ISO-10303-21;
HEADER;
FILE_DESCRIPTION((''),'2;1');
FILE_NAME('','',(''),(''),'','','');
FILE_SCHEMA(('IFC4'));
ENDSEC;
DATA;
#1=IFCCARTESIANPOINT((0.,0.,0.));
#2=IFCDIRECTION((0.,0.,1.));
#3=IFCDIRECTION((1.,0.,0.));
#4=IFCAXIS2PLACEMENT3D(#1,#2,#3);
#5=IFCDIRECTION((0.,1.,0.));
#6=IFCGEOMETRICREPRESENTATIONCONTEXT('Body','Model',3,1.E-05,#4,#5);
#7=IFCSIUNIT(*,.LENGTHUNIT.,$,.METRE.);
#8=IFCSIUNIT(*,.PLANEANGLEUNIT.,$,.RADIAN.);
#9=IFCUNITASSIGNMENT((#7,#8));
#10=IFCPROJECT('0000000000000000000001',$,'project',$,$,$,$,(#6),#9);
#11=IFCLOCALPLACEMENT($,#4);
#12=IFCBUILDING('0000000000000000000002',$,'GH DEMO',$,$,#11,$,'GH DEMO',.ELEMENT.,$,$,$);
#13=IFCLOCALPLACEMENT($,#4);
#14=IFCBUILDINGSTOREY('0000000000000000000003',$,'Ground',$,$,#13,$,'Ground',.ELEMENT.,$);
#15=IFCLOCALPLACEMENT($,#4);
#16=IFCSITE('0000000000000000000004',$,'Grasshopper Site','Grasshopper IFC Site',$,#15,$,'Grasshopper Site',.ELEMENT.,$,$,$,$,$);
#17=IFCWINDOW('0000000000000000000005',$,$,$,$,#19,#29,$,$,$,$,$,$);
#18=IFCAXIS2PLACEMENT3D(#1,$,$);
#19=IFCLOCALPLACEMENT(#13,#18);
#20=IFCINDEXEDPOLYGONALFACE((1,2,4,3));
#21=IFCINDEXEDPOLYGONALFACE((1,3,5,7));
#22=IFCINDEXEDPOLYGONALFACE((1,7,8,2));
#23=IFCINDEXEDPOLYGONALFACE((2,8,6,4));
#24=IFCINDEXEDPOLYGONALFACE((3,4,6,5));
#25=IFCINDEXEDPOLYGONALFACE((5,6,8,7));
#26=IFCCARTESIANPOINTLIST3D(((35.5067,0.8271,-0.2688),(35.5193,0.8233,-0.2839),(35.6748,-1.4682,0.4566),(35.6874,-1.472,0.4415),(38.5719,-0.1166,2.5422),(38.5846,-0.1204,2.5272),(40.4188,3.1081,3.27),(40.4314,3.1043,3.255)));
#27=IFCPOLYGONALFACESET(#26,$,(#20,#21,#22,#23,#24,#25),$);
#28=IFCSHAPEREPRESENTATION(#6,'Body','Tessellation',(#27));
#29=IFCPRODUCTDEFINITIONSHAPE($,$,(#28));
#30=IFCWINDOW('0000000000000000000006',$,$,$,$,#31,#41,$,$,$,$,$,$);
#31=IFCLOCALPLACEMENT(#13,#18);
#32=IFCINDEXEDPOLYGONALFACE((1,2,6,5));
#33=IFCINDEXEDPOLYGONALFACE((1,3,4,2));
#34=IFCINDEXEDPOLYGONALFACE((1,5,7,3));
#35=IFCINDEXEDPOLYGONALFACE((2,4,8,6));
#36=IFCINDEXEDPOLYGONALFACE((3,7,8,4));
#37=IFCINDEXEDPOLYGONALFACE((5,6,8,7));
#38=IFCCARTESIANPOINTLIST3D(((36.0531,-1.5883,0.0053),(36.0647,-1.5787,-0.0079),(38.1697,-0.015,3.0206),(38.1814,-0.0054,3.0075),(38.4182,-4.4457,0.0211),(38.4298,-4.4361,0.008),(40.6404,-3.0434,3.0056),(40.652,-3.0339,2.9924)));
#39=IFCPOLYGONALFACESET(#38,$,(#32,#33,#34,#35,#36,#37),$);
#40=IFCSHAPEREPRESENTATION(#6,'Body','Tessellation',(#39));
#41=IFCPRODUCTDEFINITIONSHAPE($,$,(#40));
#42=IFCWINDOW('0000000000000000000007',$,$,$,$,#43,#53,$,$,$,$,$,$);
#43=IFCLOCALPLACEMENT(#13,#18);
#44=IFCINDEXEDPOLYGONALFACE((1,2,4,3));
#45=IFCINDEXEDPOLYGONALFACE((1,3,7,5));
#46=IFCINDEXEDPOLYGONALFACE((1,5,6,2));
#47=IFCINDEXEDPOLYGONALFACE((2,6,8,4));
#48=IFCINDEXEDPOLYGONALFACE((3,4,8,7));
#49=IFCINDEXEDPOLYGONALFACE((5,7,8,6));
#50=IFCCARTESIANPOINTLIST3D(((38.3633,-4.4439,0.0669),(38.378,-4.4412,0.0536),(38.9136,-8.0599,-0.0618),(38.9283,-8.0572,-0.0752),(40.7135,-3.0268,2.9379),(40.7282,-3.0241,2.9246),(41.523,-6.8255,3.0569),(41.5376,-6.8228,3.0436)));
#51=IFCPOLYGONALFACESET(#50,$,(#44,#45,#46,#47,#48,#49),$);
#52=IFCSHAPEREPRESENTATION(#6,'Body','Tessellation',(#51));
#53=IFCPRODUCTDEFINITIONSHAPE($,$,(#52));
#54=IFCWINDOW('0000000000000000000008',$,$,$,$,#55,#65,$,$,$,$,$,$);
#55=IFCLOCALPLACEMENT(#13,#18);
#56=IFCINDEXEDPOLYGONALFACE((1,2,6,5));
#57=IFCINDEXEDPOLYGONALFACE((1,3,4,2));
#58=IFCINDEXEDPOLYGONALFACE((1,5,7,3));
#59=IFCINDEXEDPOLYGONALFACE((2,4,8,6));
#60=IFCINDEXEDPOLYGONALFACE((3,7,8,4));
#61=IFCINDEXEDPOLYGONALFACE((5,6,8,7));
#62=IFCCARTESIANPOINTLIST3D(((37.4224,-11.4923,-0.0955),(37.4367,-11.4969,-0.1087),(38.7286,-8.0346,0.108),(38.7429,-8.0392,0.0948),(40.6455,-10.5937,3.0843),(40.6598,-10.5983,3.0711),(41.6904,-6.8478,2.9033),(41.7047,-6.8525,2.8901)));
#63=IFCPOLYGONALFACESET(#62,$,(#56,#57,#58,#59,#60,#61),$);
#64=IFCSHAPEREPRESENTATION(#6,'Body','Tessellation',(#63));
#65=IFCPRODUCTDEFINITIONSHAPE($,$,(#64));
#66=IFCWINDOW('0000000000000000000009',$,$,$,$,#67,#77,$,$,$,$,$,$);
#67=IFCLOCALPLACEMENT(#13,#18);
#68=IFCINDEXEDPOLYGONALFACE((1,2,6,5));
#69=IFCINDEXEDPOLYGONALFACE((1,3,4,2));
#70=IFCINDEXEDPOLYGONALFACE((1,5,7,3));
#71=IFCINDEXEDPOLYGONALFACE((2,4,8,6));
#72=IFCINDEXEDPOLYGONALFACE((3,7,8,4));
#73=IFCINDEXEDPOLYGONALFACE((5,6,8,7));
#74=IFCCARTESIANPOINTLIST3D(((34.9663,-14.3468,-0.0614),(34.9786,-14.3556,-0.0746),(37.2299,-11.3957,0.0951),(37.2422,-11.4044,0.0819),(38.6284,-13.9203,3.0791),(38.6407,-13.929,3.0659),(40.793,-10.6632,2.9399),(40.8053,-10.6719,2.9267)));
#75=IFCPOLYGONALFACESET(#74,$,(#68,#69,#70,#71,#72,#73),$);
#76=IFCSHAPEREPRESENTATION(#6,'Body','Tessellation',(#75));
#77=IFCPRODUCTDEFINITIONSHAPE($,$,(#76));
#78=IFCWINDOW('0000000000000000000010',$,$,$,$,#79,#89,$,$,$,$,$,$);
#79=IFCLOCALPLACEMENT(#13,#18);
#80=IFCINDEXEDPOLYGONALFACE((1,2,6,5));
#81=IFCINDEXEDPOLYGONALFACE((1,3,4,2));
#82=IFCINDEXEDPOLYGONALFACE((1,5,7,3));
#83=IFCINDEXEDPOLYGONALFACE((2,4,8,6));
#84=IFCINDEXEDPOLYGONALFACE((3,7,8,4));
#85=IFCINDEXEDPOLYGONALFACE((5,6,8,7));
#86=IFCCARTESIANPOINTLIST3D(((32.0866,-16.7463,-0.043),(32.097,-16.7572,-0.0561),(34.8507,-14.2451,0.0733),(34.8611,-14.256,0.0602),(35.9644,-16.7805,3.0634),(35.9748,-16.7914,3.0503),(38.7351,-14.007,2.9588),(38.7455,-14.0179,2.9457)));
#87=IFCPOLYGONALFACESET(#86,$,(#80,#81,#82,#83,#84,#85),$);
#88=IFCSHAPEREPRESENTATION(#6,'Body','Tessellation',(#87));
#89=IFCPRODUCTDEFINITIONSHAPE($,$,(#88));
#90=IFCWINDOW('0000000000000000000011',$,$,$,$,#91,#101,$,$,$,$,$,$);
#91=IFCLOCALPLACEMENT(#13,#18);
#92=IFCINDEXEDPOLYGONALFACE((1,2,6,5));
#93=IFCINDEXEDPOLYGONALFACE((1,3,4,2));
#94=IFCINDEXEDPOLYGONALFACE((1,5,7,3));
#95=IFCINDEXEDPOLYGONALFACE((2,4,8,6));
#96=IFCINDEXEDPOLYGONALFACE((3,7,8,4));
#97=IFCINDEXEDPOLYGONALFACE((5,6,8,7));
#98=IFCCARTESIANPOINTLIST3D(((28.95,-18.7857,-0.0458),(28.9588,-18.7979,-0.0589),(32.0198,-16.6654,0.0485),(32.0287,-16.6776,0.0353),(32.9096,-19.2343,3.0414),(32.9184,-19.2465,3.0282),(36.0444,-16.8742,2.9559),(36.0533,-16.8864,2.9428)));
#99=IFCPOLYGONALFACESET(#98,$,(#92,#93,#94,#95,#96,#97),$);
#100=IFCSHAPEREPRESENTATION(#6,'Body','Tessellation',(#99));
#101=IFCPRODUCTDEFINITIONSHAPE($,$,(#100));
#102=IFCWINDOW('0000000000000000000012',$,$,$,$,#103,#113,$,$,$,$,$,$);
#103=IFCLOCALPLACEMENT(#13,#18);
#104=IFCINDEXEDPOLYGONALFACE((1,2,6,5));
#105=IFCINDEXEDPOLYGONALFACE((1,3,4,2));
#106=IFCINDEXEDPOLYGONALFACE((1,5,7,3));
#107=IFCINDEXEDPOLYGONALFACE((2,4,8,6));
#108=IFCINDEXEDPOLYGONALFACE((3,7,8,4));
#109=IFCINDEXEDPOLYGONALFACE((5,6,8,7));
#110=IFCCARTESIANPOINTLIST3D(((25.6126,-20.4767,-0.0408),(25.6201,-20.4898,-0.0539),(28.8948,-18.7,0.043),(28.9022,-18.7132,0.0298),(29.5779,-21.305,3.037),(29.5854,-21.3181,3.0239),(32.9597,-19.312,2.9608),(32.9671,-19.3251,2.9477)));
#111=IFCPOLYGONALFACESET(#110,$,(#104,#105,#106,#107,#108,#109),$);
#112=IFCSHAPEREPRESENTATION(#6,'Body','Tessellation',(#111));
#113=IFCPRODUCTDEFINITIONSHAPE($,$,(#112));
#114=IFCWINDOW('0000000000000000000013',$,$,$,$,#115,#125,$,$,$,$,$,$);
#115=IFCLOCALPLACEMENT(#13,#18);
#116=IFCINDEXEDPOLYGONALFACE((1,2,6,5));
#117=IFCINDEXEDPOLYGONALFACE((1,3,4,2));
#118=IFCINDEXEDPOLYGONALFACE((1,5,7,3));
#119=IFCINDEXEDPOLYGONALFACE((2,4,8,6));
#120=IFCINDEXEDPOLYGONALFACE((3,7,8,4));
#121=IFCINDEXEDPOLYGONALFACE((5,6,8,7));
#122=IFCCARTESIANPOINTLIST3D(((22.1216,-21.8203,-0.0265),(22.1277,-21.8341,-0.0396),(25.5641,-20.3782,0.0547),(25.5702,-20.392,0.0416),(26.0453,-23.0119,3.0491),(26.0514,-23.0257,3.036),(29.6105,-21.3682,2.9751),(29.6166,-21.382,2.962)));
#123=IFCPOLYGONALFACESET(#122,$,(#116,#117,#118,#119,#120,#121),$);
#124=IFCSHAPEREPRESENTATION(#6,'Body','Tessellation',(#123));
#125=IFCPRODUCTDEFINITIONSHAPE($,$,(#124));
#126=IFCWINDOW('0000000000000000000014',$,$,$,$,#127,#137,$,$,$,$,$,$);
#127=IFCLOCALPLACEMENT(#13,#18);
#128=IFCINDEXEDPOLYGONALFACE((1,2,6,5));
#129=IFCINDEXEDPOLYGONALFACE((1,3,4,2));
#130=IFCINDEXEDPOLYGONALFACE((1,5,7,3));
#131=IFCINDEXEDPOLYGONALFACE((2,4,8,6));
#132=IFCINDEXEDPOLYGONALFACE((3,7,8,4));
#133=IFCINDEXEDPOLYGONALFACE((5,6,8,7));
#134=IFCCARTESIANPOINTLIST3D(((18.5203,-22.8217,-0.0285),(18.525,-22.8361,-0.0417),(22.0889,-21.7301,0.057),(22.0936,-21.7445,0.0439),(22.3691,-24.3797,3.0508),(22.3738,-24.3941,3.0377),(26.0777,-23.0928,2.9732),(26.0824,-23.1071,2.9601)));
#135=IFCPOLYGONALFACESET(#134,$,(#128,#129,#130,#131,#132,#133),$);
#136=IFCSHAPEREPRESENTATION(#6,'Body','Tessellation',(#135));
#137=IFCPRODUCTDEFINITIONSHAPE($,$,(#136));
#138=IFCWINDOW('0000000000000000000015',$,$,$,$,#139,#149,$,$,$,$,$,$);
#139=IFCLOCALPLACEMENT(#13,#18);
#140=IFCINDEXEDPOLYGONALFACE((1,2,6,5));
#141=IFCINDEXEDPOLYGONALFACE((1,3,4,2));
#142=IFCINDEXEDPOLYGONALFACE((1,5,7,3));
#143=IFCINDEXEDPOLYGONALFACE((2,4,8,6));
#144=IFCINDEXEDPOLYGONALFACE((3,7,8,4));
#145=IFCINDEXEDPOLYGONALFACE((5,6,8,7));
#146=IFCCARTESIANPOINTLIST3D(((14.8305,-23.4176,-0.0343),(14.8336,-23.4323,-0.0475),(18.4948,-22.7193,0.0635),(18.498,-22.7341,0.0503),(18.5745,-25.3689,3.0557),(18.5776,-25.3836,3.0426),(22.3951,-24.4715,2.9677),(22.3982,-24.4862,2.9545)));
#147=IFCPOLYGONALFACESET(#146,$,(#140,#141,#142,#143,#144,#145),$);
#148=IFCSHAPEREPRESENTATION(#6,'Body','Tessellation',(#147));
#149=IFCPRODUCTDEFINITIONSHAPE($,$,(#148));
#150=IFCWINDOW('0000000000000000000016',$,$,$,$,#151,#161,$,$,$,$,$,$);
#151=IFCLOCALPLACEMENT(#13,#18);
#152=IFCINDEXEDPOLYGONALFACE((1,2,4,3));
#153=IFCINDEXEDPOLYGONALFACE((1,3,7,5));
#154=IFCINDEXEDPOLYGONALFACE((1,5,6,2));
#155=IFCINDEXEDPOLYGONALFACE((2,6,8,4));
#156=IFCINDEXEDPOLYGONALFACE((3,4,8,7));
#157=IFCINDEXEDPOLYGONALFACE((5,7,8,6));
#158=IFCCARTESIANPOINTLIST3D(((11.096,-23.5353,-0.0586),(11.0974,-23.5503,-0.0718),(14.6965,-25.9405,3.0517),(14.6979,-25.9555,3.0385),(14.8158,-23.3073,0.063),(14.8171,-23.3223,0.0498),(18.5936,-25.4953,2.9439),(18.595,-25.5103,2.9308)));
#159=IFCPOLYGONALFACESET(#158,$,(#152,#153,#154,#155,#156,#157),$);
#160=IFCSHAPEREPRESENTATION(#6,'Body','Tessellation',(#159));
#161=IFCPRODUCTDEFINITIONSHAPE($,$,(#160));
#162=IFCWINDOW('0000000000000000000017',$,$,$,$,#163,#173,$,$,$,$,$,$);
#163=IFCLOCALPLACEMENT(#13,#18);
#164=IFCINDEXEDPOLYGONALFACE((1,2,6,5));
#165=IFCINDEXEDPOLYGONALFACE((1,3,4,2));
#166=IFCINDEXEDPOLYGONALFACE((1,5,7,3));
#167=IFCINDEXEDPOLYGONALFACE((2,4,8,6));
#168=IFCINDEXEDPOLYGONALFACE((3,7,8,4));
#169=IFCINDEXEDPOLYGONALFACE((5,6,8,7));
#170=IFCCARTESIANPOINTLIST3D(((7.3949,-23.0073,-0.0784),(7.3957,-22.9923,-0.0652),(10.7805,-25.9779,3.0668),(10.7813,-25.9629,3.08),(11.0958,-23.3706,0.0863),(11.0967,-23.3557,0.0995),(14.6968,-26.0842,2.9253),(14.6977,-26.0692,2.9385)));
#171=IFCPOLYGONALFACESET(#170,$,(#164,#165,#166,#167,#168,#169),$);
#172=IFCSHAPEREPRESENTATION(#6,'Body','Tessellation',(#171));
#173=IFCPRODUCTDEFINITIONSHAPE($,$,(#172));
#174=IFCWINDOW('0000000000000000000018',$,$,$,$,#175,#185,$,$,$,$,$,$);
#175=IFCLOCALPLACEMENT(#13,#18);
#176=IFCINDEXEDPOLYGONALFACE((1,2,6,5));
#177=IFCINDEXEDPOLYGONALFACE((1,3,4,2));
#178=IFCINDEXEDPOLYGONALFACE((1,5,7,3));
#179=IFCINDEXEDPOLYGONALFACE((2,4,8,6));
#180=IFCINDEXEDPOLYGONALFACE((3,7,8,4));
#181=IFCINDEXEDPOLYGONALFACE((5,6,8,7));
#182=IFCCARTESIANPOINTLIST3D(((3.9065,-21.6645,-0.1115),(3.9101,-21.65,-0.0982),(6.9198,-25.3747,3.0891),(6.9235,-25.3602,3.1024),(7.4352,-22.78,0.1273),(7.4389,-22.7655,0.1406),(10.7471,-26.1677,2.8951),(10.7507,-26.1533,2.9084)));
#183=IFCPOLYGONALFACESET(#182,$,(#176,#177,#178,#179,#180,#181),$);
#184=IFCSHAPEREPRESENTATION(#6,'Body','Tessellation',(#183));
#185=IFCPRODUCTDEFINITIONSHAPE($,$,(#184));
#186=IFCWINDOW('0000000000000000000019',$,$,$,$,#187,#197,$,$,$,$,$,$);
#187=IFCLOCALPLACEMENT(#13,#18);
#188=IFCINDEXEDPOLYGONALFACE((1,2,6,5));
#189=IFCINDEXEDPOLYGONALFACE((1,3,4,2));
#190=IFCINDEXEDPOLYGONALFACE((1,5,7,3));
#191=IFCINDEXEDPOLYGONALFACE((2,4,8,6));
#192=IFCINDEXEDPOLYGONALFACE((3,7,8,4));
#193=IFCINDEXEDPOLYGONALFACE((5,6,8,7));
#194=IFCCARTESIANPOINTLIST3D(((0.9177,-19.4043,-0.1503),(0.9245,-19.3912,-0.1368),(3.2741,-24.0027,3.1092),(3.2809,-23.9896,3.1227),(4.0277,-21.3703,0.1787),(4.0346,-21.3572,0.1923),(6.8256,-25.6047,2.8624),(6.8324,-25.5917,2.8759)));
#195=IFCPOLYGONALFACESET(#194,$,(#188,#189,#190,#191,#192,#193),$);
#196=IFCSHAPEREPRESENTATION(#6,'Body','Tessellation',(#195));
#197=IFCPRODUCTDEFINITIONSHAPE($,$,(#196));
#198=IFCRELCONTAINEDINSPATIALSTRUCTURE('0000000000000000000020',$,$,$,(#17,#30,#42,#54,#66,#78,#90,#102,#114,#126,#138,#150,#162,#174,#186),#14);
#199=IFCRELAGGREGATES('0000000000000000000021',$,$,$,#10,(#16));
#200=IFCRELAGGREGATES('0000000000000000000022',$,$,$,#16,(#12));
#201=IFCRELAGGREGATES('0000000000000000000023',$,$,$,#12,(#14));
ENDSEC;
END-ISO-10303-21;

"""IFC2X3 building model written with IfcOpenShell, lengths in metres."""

from ifc_helpers import new_model, si_unit, direction, frame, origin_with_axes, place, context, project, spatial, polyline, outline, extrude, element, save


model = new_model("IFC2X3")

# Units and contexts
model_context = context("Model", 3, precision=1e-05, world=origin_with_axes(), true_north=direction((0.0, 1.0, 0.0)), identifier="Body")
ifc_project = project(units=[si_unit("LENGTHUNIT", "METRE"), si_unit("PLANEANGLEUNIT", "RADIAN")], contexts=[model_context])

# Site, building, storey
site_placement = place(None, origin_with_axes())
site = spatial("IfcSite", under=ifc_project, at=site_placement, Name="Grasshopper Site", Description="Grasshopper IFC Site", LongName="Grasshopper Site", CompositionType="ELEMENT")
building_placement = place(None, origin_with_axes())
building = spatial("IfcBuilding", under=site, at=building_placement, Name="GH DEMO", LongName="GH DEMO", CompositionType="ELEMENT")
storey_placement = place(None, origin_with_axes())
storey = spatial("IfcBuildingStorey", under=building, at=storey_placement, Name="Ground", LongName="Ground", CompositionType="ELEMENT")

# Windows
window_1_placement = place(None, origin_with_axes())
element("IfcWindow", 1, at=window_1_placement, inside=storey, context=model_context, shape_type="SweptSolid", body=[
    extrude(outline(polyline([(0.0, 0.0), (6.4696, 0.0), (3.5322, 2.3898), (-0.2849, 2.3961), (0.0, 0.0)])), frame((35.5067, 0.8271, -0.2688), z_axis=(0.630711, -0.191495, -0.75202), x_axis=(0.75926, 0.35258, 0.547002)), (0.0, 0.0, 1.0), 0.02),
])
window_2_placement = place(None, origin_with_axes())
element("IfcWindow", 2, at=window_2_placement, inside=storey, context=model_context, shape_type="SweptSolid", body=[
    extrude(outline(polyline([(0.0, 0.0), (4.006, 0.0), (4.1108, 3.907), (0.1395, 3.7067), (0.0, 0.0)])), frame((36.0647, -1.5787, -0.0079), z_axis=(0.581941, 0.478026, -0.657903), x_axis=(0.528377, 0.392723, 0.752719)), (0.0, 0.0, -1.0), 0.02),
])
window_3_placement = place(None, origin_with_axes())
element("IfcWindow", 3, at=window_3_placement, inside=storey, context=model_context, shape_type="SweptSolid", body=[
    extrude(outline(polyline([(0.0, 0.0), (3.9717, 0.0), (3.1813, 3.8046), (-1.0577, 3.5038), (0.0, 0.0)])), frame((38.3633, -4.4439, 0.0669), z_axis=(0.732908, 0.135283, -0.666742), x_axis=(0.591742, 0.356808, 0.722862)), (0.0, 0.0, 1.0), 0.02),
])
window_4_placement = place(None, origin_with_axes())
element("IfcWindow", 4, at=window_4_placement, inside=storey, context=model_context, shape_type="SweptSolid", body=[
    extrude(outline(polyline([(0.0, 0.0), (4.242, 0.0), (2.5837, 3.5223), (-2.0134, 3.1064), (0.0, 0.0)])), frame((38.7286, -8.0346, 0.108), z_axis=(0.715186, -0.231353, -0.659534), x_axis=(0.698199, 0.279765, 0.658977)), (0.0, 0.0, 1.0), 0.02),
])
window_5_placement = place(None, origin_with_axes())
element("IfcWindow", 5, at=window_5_placement, inside=storey, context=model_context, shape_type="SweptSolid", body=[
    extrude(outline(polyline([(0.0, 0.0), (4.6179, 0.0), (2.5169, 3.3014), (-2.3111, 2.9184), (0.0, 0.0)])), frame((37.2422, -11.4044, 0.0819), z_axis=(0.614461, -0.436451, -0.657228), x_axis=(0.771581, 0.158615, 0.616039)), (0.0, 0.0, -1.0), 0.02),
])
window_6_placement = place(None, origin_with_axes())
element("IfcWindow", 6, at=window_6_placement, inside=storey, context=model_context, shape_type="SweptSolid", body=[
    extrude(outline(polyline([(0.0, 0.0), (4.8447, 0.0), (2.5492, 3.1797), (-2.4084, 2.8476), (0.0, 0.0)])), frame((34.8611, -14.256, 0.0602), z_axis=(0.521115, -0.545356, -0.656526), x_axis=(0.801786, 0.049149, 0.595587)), (0.0, 0.0, -1.0), 0.02),
])
window_7_placement = place(None, origin_with_axes())
element("IfcWindow", 7, at=window_7_placement, inside=storey, context=model_context, shape_type="SweptSolid", body=[
    extrude(outline(polyline([(0.0, 0.0), (4.9693, 0.0), (2.5796, 3.1135), (-2.4523, 2.8133), (0.0, 0.0)])), frame((32.0198, -16.6654, 0.0485), z_axis=(0.442357, -0.611313, -0.656214), x_axis=(0.809884, -0.042013, 0.585084)), (0.0, 0.0, 1.0), 0.02),
])
window_8_placement = place(None, origin_with_axes())
element("IfcWindow", 8, at=window_8_placement, inside=storey, context=model_context, shape_type="SweptSolid", body=[
    extrude(outline(polyline([(0.0, 0.0), (5.041, 0.0), (2.6002, 3.0751), (-2.4794, 2.7907), (0.0, 0.0)])), frame((28.8948, -18.7, 0.043), z_axis=(0.37213, -0.656532, -0.656114), x_axis=(0.806367, -0.121396, 0.578822)), (0.0, 0.0, 1.0), 0.02),
])
window_9_placement = place(None, origin_with_axes())
element("IfcWindow", 9, at=window_9_placement, inside=storey, context=model_context, shape_type="SweptSolid", body=[
    extrude(outline(polyline([(0.0, 0.0), (5.0874, 0.0), (2.6142, 3.0496), (-2.5041, 2.7689), (0.0, 0.0)])), frame((25.5702, -20.392, 0.0416), z_axis=(0.304678, -0.690364, -0.656178), x_axis=(0.795367, -0.194596, 0.574041)), (0.0, 0.0, -1.0), 0.02),
])
window_10_placement = place(None, origin_with_axes())
element("IfcWindow", 10, at=window_10_placement, inside=storey, context=model_context, shape_type="SweptSolid", body=[
    extrude(outline(polyline([(0.0, 0.0), (5.1256, 0.0), (2.6258, 3.0277), (-2.5356, 2.7394), (0.0, 0.0)])), frame((22.0936, -21.7445, 0.0439), z_axis=(0.235014, -0.716849, -0.656427), x_axis=(0.77822, -0.265853, 0.568942)), (0.0, 0.0, -1.0), 0.02),
])
window_11_placement = place(None, origin_with_axes())
element("IfcWindow", 11, at=window_11_placement, inside=storey, context=model_context, shape_type="SweptSolid", body=[
    extrude(outline(polyline([(0.0, 0.0), (5.1688, 0.0), (2.6395, 3.0021), (-2.5833, 2.6928), (0.0, 0.0)])), frame((18.498, -22.7341, 0.0503), z_axis=(0.158012, -0.737178, -0.656963), x_axis=(0.75458, -0.338988, 0.561869)), (0.0, 0.0, -1.0), 0.02),
])
window_12_placement = place(None, origin_with_axes())
element("IfcWindow", 12, at=window_12_placement, inside=storey, context=model_context, shape_type="SweptSolid", body=[
    extrude(outline(polyline([(0.0, 0.0), (5.2306, 0.0), (2.6615, 2.9659), (-2.6582, 2.6148), (0.0, 0.0)])), frame((14.8158, -23.3073, 0.063), z_axis=(0.067491, -0.749936, -0.658059), x_axis=(0.722258, -0.418306, 0.550784)), (0.0, 0.0, 1.0), 0.02),
])
window_13_placement = place(None, origin_with_axes())
element("IfcWindow", 13, at=window_13_placement, inside=storey, context=model_context, shape_type="SweptSolid", body=[
    extrude(outline(polyline([(0.0, 0.0), (5.3283, 0.0), (2.7028, 2.9113), (-2.774, 2.4822), (0.0, 0.0)])), frame((11.0958, -23.3706, 0.0863), z_axis=(-0.044215, -0.749613, -0.660398), x_axis=(0.67583, -0.50927, 0.53282)), (0.0, 0.0, -1.0), 0.02),
])
window_14_placement = place(None, origin_with_axes())
element("IfcWindow", 14, at=window_14_placement, inside=storey, context=model_context, shape_type="SweptSolid", body=[
    extrude(outline(polyline([(0.0, 0.0), (5.4869, 0.0), (2.785, 2.8309), (-2.9391, 2.2616), (0.0, 0.0)])), frame((7.4352, -22.78, 0.1273), z_axis=(-0.183614, -0.723324, -0.665649), x_axis=(0.603591, -0.617433, 0.504434)), (0.0, 0.0, -1.0), 0.02),
])
window_15_placement = place(None, origin_with_axes())
element("IfcWindow", 15, at=window_15_placement, inside=storey, context=model_context, shape_type="SweptSolid", body=[
    extrude(outline(polyline([(0.0, 0.0), (5.7411, 0.0), (2.9441, 2.7235), (-3.1195, 1.9785), (0.0, 0.0)])), frame((4.0277, -21.3703, 0.1787), z_axis=(-0.34181, -0.653715, -0.675146), x_axis=(0.487331, -0.737572, 0.467435)), (0.0, 0.0, -1.0), 0.02),
])

save(model, "model.ifc")
